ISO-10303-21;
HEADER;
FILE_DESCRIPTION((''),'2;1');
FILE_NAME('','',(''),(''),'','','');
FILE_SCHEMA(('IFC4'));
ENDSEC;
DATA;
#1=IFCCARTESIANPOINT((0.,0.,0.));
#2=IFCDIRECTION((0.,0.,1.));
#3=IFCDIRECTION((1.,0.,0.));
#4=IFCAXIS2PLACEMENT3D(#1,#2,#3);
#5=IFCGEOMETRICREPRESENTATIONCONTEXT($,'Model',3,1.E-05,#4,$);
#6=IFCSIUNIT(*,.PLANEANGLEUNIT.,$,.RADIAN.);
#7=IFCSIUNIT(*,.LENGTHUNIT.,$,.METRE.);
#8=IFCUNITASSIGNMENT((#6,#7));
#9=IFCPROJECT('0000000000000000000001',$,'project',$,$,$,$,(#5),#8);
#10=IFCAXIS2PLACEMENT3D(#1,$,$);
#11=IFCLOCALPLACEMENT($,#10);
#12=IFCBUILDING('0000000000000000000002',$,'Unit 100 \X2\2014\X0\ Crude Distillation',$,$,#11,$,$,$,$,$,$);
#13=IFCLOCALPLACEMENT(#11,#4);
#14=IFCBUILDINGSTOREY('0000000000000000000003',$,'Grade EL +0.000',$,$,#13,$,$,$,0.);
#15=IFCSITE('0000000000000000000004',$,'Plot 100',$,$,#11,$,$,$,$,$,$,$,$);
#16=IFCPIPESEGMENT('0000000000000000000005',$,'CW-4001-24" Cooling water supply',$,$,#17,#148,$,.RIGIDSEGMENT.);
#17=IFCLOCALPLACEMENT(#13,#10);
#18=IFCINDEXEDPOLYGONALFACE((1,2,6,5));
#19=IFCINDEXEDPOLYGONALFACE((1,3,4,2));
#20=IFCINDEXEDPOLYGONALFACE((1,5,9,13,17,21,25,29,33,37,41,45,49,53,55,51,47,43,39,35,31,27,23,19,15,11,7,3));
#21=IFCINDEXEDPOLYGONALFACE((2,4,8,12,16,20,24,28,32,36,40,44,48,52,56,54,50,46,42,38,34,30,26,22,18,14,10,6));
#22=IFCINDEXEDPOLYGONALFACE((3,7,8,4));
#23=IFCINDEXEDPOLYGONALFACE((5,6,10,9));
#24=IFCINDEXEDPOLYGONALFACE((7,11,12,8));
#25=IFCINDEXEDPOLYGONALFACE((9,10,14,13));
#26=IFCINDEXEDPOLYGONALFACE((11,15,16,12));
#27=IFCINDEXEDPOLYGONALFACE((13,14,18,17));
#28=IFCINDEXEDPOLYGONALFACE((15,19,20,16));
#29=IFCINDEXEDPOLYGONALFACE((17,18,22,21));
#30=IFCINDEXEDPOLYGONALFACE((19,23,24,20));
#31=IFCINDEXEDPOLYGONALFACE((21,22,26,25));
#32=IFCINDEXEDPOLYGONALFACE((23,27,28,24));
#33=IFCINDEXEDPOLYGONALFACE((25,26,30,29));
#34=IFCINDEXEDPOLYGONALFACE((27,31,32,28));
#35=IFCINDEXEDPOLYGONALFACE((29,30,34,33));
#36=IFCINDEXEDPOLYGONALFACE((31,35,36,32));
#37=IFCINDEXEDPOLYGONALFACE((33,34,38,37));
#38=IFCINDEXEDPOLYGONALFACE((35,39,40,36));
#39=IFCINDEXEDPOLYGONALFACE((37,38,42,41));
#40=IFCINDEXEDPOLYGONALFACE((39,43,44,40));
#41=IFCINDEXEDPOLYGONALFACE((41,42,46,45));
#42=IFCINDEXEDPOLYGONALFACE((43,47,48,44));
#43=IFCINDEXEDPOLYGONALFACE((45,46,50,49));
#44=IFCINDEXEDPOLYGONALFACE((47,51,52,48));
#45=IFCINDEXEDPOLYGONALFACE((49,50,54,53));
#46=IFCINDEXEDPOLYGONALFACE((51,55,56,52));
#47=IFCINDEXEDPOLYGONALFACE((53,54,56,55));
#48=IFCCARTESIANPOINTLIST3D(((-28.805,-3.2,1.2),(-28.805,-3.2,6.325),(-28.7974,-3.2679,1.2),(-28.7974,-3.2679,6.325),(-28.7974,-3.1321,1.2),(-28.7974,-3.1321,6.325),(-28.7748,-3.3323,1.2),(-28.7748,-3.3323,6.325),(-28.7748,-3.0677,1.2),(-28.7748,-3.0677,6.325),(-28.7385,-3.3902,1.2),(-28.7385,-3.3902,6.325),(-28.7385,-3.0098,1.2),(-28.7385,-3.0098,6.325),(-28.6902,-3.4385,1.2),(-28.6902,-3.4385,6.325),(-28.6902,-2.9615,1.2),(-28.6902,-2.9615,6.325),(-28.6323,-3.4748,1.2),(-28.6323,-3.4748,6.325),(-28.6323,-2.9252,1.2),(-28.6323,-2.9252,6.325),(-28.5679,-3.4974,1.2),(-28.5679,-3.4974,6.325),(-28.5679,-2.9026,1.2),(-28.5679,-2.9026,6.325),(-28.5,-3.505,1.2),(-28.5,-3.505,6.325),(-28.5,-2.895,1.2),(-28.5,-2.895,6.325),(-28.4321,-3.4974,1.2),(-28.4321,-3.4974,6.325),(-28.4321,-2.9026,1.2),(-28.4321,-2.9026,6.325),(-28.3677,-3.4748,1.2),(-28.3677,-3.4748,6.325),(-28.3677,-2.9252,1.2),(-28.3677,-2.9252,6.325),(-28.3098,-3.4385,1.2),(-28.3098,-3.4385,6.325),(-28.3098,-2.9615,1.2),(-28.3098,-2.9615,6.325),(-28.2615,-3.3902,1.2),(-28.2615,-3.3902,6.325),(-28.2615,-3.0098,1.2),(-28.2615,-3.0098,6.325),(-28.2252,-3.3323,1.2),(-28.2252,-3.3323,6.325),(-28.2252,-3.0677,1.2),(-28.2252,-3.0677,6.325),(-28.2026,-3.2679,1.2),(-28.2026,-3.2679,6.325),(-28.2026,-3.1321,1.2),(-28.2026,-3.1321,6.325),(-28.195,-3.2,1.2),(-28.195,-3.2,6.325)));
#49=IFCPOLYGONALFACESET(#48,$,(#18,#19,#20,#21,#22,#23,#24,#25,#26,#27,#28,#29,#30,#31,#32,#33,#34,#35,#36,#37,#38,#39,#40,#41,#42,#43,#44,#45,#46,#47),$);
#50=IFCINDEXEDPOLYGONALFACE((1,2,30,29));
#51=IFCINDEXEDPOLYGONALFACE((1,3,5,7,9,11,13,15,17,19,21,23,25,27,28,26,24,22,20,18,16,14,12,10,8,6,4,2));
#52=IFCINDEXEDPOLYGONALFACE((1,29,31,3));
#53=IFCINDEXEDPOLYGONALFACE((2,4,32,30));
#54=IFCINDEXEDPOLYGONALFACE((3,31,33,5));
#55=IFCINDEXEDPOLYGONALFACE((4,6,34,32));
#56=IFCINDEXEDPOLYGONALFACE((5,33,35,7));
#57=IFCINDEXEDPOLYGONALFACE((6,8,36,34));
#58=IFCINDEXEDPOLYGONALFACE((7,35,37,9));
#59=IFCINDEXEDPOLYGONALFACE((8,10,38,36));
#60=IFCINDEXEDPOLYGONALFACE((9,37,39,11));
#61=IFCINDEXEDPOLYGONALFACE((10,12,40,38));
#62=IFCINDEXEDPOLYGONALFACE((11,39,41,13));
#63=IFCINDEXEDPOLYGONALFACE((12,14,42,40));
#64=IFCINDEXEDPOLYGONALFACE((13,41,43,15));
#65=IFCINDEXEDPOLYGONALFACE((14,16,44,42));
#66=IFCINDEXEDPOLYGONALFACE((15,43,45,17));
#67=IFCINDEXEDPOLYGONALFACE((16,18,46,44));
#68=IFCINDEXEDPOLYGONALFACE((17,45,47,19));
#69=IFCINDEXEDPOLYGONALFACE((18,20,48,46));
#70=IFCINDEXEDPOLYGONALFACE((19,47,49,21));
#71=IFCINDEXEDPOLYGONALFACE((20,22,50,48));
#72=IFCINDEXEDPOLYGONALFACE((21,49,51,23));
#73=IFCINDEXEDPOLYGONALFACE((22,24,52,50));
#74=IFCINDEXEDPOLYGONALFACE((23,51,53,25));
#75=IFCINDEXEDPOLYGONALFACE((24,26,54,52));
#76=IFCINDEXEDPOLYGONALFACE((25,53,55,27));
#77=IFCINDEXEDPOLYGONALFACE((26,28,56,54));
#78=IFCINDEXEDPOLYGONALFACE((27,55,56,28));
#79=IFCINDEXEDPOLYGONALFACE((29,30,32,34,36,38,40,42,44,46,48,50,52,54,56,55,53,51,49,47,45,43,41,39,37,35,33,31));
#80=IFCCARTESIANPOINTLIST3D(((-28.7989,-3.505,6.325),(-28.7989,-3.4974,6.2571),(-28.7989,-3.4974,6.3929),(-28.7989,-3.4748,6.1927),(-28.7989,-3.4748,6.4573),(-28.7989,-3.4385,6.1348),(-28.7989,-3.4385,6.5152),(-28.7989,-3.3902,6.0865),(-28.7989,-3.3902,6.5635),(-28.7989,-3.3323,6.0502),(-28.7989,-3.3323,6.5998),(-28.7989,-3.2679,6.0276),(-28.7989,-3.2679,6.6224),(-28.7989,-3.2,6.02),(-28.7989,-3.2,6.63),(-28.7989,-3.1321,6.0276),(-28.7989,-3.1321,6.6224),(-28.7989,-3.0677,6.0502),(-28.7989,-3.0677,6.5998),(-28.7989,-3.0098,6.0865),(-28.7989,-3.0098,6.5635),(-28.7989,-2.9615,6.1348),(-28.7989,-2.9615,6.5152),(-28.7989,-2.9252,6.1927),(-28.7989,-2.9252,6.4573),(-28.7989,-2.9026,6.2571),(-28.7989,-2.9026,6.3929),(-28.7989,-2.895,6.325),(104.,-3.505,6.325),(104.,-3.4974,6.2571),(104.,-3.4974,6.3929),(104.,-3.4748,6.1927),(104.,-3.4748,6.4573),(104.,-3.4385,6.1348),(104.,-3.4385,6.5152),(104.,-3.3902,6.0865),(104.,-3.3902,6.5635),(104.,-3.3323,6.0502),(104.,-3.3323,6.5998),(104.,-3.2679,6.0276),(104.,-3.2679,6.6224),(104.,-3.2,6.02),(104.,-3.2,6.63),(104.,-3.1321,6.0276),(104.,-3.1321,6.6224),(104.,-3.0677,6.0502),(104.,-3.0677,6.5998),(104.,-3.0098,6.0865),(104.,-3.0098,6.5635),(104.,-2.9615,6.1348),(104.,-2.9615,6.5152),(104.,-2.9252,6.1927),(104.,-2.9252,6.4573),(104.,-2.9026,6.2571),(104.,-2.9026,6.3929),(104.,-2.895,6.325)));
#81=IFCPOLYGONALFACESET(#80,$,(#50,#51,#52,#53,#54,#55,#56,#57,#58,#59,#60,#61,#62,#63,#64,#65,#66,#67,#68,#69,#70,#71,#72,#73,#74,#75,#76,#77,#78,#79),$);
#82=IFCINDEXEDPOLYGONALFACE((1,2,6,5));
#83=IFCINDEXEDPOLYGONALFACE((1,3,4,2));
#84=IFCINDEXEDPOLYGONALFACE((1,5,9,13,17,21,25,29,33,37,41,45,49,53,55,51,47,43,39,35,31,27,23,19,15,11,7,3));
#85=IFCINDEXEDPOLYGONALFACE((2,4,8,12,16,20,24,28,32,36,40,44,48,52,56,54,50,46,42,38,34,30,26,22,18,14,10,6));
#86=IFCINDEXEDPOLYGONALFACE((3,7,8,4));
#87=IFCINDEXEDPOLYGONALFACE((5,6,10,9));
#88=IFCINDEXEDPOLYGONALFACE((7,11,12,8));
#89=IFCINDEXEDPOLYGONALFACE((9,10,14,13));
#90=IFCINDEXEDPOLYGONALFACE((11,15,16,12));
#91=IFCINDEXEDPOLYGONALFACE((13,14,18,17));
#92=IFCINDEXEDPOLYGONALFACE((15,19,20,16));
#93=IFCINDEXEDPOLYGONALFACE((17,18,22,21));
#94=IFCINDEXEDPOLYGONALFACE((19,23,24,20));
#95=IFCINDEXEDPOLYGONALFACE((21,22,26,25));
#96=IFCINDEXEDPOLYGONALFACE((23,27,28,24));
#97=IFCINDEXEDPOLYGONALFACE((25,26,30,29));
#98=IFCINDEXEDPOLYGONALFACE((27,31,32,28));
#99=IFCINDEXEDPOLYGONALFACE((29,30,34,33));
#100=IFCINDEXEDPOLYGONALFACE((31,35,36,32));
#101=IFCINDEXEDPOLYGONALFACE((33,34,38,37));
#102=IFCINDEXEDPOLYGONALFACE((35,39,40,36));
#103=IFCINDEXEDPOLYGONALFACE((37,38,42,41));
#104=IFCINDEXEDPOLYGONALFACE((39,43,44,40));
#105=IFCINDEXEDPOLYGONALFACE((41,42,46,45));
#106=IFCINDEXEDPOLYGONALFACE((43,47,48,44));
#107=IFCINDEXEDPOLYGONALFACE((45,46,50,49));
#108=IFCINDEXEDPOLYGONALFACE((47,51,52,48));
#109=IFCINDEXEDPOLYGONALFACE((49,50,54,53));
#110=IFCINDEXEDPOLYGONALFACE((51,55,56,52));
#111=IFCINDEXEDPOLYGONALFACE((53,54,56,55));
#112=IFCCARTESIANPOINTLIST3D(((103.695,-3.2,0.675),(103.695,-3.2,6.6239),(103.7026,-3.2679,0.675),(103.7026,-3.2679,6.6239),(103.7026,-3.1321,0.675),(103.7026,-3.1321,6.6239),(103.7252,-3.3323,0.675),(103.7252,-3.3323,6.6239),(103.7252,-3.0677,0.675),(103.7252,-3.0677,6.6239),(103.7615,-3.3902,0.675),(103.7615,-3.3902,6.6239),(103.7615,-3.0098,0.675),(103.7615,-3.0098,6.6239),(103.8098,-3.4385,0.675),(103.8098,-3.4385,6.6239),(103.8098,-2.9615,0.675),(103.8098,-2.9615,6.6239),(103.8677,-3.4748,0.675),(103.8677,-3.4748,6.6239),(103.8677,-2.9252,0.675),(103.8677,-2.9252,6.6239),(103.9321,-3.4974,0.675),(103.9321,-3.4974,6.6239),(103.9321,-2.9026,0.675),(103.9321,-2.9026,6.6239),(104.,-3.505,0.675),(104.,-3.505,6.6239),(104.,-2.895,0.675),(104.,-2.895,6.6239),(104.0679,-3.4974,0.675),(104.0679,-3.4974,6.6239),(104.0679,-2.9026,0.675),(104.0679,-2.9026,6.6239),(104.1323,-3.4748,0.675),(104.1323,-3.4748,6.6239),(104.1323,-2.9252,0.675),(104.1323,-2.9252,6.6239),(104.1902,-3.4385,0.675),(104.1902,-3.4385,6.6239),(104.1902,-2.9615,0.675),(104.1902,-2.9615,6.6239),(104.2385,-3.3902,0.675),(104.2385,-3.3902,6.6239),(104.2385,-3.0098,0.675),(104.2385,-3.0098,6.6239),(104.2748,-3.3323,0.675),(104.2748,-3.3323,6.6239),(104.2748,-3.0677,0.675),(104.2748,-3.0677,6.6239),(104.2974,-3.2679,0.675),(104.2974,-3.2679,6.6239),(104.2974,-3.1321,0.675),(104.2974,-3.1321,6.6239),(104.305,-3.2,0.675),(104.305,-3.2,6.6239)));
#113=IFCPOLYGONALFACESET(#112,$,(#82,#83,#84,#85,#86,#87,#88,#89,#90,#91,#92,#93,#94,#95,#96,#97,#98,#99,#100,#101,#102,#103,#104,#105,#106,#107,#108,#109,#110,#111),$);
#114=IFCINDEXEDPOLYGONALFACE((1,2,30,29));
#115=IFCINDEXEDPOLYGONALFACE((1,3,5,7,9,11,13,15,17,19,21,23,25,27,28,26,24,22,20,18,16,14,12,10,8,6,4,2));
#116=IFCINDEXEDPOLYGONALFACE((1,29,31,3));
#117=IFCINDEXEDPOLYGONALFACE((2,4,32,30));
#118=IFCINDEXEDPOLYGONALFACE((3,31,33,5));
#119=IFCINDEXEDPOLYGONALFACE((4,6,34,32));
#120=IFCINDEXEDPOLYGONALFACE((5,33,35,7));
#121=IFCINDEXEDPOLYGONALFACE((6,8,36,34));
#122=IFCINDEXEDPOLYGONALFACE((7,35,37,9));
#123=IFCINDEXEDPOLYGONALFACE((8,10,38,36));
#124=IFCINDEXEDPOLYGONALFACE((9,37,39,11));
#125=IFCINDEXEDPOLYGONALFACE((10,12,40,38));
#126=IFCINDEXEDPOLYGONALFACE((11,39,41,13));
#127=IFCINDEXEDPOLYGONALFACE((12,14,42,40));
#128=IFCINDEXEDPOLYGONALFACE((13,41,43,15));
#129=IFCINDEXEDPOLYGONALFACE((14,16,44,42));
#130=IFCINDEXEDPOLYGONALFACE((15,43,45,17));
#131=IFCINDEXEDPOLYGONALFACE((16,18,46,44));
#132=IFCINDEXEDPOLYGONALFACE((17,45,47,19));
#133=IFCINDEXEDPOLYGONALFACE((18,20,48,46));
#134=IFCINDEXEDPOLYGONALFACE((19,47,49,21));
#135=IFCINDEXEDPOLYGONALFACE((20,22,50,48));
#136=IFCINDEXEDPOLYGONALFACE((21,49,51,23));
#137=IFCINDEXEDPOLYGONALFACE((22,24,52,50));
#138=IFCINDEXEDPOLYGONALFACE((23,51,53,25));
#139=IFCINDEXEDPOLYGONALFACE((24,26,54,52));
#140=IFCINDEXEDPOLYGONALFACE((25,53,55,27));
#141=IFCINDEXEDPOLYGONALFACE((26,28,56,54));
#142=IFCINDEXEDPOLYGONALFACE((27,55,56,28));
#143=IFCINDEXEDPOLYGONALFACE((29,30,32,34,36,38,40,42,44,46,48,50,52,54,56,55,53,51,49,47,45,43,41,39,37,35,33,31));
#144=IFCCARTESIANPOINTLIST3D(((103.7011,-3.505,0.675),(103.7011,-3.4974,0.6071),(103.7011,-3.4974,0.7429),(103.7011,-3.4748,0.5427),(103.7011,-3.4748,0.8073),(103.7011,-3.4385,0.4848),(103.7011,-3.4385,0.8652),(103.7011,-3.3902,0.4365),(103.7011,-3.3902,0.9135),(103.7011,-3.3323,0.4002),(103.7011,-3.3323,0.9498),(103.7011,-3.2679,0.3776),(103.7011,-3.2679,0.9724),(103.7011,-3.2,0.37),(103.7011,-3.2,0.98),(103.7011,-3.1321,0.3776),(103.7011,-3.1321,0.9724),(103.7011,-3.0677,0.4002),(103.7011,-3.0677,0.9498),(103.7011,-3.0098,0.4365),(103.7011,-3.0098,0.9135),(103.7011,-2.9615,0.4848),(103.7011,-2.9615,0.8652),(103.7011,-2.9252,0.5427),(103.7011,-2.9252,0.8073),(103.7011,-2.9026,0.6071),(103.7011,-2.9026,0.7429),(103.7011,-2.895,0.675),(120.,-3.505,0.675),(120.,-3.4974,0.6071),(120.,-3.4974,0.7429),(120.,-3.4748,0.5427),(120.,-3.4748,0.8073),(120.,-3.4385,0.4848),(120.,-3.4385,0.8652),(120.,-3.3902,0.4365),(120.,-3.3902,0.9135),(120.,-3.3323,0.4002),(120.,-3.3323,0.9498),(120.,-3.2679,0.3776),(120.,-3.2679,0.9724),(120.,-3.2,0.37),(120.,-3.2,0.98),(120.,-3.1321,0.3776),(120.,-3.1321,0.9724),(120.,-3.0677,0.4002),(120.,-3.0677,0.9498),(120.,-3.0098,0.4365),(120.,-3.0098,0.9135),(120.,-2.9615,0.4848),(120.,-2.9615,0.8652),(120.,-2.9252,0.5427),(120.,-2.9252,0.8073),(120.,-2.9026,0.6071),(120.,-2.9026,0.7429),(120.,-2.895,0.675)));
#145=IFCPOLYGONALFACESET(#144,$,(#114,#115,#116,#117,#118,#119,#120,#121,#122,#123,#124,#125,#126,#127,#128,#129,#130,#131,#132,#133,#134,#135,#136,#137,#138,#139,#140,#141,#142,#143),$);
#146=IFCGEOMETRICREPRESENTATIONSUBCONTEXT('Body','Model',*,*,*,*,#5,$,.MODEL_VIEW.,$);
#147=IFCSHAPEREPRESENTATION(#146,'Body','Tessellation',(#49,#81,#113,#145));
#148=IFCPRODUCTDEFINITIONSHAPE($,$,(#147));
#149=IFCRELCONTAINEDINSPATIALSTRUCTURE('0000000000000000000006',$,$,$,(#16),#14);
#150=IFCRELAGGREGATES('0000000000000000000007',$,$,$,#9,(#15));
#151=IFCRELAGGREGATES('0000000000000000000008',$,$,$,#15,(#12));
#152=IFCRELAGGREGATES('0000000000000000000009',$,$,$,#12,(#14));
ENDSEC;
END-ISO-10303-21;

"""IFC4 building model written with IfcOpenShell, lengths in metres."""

from ifc_helpers import new_model, si_unit, frame, origin, origin_with_axes, origin_2d, place, context, subcontext, project, spatial, circle, extrude, element, save


model = new_model("IFC4")

# Units and contexts
model_context = context("Model", 3, precision=1e-05, world=origin_with_axes())
body_context = subcontext(model_context, "Body", "Model", "MODEL_VIEW")
ifc_project = project(units=[si_unit("PLANEANGLEUNIT", "RADIAN"), si_unit("LENGTHUNIT", "METRE")], contexts=[model_context])

# Site, building, storey
placement = place(None, origin())
site = spatial("IfcSite", under=ifc_project, at=placement, Name="Plot 100")
building = spatial("IfcBuilding", under=site, at=placement, Name="Unit 100 — Crude Distillation")
storey_placement = place(placement, origin_with_axes())
storey = spatial("IfcBuildingStorey", under=building, at=storey_placement, Name="Grade EL +0.000", Elevation=0.0)

# Pipe segment
pipe_segment_1_placement = place(storey_placement, origin_with_axes())
element("IfcPipeSegment", 1, at=pipe_segment_1_placement, inside=storey, Name="CW-4001-24\" Cooling water supply", PredefinedType="RIGIDSEGMENT", context=body_context, shape_type="SweptSolid", body=[
    extrude(circle(Radius=0.305, at=origin_2d()), frame((-28.5, -3.2, 1.2), z_axis=(0.0, 0.0, 1.0), x_axis=(1.0, 0.0, 0.0)), (0.0, 0.0, 1.0), 5.125),
    extrude(circle(Radius=0.305, at=origin_2d()), frame((-28.7989, -3.2, 6.325), z_axis=(1.0, 0.0, 0.0), x_axis=(0.0, 1.0, 0.0)), (0.0, 0.0, 1.0), 132.7989),
    extrude(circle(Radius=0.305, at=origin_2d()), frame((104.0, -3.2, 6.6239), z_axis=(0.0, 0.0, -1.0), x_axis=(1.0, 0.0, 0.0)), (0.0, 0.0, 1.0), 5.9489),
    extrude(circle(Radius=0.305, at=origin_2d()), frame((103.7011, -3.2, 0.675), z_axis=(1.0, 0.0, 0.0), x_axis=(0.0, 1.0, 0.0)), (0.0, 0.0, 1.0), 16.2989),
])

save(model, "model.ifc")
